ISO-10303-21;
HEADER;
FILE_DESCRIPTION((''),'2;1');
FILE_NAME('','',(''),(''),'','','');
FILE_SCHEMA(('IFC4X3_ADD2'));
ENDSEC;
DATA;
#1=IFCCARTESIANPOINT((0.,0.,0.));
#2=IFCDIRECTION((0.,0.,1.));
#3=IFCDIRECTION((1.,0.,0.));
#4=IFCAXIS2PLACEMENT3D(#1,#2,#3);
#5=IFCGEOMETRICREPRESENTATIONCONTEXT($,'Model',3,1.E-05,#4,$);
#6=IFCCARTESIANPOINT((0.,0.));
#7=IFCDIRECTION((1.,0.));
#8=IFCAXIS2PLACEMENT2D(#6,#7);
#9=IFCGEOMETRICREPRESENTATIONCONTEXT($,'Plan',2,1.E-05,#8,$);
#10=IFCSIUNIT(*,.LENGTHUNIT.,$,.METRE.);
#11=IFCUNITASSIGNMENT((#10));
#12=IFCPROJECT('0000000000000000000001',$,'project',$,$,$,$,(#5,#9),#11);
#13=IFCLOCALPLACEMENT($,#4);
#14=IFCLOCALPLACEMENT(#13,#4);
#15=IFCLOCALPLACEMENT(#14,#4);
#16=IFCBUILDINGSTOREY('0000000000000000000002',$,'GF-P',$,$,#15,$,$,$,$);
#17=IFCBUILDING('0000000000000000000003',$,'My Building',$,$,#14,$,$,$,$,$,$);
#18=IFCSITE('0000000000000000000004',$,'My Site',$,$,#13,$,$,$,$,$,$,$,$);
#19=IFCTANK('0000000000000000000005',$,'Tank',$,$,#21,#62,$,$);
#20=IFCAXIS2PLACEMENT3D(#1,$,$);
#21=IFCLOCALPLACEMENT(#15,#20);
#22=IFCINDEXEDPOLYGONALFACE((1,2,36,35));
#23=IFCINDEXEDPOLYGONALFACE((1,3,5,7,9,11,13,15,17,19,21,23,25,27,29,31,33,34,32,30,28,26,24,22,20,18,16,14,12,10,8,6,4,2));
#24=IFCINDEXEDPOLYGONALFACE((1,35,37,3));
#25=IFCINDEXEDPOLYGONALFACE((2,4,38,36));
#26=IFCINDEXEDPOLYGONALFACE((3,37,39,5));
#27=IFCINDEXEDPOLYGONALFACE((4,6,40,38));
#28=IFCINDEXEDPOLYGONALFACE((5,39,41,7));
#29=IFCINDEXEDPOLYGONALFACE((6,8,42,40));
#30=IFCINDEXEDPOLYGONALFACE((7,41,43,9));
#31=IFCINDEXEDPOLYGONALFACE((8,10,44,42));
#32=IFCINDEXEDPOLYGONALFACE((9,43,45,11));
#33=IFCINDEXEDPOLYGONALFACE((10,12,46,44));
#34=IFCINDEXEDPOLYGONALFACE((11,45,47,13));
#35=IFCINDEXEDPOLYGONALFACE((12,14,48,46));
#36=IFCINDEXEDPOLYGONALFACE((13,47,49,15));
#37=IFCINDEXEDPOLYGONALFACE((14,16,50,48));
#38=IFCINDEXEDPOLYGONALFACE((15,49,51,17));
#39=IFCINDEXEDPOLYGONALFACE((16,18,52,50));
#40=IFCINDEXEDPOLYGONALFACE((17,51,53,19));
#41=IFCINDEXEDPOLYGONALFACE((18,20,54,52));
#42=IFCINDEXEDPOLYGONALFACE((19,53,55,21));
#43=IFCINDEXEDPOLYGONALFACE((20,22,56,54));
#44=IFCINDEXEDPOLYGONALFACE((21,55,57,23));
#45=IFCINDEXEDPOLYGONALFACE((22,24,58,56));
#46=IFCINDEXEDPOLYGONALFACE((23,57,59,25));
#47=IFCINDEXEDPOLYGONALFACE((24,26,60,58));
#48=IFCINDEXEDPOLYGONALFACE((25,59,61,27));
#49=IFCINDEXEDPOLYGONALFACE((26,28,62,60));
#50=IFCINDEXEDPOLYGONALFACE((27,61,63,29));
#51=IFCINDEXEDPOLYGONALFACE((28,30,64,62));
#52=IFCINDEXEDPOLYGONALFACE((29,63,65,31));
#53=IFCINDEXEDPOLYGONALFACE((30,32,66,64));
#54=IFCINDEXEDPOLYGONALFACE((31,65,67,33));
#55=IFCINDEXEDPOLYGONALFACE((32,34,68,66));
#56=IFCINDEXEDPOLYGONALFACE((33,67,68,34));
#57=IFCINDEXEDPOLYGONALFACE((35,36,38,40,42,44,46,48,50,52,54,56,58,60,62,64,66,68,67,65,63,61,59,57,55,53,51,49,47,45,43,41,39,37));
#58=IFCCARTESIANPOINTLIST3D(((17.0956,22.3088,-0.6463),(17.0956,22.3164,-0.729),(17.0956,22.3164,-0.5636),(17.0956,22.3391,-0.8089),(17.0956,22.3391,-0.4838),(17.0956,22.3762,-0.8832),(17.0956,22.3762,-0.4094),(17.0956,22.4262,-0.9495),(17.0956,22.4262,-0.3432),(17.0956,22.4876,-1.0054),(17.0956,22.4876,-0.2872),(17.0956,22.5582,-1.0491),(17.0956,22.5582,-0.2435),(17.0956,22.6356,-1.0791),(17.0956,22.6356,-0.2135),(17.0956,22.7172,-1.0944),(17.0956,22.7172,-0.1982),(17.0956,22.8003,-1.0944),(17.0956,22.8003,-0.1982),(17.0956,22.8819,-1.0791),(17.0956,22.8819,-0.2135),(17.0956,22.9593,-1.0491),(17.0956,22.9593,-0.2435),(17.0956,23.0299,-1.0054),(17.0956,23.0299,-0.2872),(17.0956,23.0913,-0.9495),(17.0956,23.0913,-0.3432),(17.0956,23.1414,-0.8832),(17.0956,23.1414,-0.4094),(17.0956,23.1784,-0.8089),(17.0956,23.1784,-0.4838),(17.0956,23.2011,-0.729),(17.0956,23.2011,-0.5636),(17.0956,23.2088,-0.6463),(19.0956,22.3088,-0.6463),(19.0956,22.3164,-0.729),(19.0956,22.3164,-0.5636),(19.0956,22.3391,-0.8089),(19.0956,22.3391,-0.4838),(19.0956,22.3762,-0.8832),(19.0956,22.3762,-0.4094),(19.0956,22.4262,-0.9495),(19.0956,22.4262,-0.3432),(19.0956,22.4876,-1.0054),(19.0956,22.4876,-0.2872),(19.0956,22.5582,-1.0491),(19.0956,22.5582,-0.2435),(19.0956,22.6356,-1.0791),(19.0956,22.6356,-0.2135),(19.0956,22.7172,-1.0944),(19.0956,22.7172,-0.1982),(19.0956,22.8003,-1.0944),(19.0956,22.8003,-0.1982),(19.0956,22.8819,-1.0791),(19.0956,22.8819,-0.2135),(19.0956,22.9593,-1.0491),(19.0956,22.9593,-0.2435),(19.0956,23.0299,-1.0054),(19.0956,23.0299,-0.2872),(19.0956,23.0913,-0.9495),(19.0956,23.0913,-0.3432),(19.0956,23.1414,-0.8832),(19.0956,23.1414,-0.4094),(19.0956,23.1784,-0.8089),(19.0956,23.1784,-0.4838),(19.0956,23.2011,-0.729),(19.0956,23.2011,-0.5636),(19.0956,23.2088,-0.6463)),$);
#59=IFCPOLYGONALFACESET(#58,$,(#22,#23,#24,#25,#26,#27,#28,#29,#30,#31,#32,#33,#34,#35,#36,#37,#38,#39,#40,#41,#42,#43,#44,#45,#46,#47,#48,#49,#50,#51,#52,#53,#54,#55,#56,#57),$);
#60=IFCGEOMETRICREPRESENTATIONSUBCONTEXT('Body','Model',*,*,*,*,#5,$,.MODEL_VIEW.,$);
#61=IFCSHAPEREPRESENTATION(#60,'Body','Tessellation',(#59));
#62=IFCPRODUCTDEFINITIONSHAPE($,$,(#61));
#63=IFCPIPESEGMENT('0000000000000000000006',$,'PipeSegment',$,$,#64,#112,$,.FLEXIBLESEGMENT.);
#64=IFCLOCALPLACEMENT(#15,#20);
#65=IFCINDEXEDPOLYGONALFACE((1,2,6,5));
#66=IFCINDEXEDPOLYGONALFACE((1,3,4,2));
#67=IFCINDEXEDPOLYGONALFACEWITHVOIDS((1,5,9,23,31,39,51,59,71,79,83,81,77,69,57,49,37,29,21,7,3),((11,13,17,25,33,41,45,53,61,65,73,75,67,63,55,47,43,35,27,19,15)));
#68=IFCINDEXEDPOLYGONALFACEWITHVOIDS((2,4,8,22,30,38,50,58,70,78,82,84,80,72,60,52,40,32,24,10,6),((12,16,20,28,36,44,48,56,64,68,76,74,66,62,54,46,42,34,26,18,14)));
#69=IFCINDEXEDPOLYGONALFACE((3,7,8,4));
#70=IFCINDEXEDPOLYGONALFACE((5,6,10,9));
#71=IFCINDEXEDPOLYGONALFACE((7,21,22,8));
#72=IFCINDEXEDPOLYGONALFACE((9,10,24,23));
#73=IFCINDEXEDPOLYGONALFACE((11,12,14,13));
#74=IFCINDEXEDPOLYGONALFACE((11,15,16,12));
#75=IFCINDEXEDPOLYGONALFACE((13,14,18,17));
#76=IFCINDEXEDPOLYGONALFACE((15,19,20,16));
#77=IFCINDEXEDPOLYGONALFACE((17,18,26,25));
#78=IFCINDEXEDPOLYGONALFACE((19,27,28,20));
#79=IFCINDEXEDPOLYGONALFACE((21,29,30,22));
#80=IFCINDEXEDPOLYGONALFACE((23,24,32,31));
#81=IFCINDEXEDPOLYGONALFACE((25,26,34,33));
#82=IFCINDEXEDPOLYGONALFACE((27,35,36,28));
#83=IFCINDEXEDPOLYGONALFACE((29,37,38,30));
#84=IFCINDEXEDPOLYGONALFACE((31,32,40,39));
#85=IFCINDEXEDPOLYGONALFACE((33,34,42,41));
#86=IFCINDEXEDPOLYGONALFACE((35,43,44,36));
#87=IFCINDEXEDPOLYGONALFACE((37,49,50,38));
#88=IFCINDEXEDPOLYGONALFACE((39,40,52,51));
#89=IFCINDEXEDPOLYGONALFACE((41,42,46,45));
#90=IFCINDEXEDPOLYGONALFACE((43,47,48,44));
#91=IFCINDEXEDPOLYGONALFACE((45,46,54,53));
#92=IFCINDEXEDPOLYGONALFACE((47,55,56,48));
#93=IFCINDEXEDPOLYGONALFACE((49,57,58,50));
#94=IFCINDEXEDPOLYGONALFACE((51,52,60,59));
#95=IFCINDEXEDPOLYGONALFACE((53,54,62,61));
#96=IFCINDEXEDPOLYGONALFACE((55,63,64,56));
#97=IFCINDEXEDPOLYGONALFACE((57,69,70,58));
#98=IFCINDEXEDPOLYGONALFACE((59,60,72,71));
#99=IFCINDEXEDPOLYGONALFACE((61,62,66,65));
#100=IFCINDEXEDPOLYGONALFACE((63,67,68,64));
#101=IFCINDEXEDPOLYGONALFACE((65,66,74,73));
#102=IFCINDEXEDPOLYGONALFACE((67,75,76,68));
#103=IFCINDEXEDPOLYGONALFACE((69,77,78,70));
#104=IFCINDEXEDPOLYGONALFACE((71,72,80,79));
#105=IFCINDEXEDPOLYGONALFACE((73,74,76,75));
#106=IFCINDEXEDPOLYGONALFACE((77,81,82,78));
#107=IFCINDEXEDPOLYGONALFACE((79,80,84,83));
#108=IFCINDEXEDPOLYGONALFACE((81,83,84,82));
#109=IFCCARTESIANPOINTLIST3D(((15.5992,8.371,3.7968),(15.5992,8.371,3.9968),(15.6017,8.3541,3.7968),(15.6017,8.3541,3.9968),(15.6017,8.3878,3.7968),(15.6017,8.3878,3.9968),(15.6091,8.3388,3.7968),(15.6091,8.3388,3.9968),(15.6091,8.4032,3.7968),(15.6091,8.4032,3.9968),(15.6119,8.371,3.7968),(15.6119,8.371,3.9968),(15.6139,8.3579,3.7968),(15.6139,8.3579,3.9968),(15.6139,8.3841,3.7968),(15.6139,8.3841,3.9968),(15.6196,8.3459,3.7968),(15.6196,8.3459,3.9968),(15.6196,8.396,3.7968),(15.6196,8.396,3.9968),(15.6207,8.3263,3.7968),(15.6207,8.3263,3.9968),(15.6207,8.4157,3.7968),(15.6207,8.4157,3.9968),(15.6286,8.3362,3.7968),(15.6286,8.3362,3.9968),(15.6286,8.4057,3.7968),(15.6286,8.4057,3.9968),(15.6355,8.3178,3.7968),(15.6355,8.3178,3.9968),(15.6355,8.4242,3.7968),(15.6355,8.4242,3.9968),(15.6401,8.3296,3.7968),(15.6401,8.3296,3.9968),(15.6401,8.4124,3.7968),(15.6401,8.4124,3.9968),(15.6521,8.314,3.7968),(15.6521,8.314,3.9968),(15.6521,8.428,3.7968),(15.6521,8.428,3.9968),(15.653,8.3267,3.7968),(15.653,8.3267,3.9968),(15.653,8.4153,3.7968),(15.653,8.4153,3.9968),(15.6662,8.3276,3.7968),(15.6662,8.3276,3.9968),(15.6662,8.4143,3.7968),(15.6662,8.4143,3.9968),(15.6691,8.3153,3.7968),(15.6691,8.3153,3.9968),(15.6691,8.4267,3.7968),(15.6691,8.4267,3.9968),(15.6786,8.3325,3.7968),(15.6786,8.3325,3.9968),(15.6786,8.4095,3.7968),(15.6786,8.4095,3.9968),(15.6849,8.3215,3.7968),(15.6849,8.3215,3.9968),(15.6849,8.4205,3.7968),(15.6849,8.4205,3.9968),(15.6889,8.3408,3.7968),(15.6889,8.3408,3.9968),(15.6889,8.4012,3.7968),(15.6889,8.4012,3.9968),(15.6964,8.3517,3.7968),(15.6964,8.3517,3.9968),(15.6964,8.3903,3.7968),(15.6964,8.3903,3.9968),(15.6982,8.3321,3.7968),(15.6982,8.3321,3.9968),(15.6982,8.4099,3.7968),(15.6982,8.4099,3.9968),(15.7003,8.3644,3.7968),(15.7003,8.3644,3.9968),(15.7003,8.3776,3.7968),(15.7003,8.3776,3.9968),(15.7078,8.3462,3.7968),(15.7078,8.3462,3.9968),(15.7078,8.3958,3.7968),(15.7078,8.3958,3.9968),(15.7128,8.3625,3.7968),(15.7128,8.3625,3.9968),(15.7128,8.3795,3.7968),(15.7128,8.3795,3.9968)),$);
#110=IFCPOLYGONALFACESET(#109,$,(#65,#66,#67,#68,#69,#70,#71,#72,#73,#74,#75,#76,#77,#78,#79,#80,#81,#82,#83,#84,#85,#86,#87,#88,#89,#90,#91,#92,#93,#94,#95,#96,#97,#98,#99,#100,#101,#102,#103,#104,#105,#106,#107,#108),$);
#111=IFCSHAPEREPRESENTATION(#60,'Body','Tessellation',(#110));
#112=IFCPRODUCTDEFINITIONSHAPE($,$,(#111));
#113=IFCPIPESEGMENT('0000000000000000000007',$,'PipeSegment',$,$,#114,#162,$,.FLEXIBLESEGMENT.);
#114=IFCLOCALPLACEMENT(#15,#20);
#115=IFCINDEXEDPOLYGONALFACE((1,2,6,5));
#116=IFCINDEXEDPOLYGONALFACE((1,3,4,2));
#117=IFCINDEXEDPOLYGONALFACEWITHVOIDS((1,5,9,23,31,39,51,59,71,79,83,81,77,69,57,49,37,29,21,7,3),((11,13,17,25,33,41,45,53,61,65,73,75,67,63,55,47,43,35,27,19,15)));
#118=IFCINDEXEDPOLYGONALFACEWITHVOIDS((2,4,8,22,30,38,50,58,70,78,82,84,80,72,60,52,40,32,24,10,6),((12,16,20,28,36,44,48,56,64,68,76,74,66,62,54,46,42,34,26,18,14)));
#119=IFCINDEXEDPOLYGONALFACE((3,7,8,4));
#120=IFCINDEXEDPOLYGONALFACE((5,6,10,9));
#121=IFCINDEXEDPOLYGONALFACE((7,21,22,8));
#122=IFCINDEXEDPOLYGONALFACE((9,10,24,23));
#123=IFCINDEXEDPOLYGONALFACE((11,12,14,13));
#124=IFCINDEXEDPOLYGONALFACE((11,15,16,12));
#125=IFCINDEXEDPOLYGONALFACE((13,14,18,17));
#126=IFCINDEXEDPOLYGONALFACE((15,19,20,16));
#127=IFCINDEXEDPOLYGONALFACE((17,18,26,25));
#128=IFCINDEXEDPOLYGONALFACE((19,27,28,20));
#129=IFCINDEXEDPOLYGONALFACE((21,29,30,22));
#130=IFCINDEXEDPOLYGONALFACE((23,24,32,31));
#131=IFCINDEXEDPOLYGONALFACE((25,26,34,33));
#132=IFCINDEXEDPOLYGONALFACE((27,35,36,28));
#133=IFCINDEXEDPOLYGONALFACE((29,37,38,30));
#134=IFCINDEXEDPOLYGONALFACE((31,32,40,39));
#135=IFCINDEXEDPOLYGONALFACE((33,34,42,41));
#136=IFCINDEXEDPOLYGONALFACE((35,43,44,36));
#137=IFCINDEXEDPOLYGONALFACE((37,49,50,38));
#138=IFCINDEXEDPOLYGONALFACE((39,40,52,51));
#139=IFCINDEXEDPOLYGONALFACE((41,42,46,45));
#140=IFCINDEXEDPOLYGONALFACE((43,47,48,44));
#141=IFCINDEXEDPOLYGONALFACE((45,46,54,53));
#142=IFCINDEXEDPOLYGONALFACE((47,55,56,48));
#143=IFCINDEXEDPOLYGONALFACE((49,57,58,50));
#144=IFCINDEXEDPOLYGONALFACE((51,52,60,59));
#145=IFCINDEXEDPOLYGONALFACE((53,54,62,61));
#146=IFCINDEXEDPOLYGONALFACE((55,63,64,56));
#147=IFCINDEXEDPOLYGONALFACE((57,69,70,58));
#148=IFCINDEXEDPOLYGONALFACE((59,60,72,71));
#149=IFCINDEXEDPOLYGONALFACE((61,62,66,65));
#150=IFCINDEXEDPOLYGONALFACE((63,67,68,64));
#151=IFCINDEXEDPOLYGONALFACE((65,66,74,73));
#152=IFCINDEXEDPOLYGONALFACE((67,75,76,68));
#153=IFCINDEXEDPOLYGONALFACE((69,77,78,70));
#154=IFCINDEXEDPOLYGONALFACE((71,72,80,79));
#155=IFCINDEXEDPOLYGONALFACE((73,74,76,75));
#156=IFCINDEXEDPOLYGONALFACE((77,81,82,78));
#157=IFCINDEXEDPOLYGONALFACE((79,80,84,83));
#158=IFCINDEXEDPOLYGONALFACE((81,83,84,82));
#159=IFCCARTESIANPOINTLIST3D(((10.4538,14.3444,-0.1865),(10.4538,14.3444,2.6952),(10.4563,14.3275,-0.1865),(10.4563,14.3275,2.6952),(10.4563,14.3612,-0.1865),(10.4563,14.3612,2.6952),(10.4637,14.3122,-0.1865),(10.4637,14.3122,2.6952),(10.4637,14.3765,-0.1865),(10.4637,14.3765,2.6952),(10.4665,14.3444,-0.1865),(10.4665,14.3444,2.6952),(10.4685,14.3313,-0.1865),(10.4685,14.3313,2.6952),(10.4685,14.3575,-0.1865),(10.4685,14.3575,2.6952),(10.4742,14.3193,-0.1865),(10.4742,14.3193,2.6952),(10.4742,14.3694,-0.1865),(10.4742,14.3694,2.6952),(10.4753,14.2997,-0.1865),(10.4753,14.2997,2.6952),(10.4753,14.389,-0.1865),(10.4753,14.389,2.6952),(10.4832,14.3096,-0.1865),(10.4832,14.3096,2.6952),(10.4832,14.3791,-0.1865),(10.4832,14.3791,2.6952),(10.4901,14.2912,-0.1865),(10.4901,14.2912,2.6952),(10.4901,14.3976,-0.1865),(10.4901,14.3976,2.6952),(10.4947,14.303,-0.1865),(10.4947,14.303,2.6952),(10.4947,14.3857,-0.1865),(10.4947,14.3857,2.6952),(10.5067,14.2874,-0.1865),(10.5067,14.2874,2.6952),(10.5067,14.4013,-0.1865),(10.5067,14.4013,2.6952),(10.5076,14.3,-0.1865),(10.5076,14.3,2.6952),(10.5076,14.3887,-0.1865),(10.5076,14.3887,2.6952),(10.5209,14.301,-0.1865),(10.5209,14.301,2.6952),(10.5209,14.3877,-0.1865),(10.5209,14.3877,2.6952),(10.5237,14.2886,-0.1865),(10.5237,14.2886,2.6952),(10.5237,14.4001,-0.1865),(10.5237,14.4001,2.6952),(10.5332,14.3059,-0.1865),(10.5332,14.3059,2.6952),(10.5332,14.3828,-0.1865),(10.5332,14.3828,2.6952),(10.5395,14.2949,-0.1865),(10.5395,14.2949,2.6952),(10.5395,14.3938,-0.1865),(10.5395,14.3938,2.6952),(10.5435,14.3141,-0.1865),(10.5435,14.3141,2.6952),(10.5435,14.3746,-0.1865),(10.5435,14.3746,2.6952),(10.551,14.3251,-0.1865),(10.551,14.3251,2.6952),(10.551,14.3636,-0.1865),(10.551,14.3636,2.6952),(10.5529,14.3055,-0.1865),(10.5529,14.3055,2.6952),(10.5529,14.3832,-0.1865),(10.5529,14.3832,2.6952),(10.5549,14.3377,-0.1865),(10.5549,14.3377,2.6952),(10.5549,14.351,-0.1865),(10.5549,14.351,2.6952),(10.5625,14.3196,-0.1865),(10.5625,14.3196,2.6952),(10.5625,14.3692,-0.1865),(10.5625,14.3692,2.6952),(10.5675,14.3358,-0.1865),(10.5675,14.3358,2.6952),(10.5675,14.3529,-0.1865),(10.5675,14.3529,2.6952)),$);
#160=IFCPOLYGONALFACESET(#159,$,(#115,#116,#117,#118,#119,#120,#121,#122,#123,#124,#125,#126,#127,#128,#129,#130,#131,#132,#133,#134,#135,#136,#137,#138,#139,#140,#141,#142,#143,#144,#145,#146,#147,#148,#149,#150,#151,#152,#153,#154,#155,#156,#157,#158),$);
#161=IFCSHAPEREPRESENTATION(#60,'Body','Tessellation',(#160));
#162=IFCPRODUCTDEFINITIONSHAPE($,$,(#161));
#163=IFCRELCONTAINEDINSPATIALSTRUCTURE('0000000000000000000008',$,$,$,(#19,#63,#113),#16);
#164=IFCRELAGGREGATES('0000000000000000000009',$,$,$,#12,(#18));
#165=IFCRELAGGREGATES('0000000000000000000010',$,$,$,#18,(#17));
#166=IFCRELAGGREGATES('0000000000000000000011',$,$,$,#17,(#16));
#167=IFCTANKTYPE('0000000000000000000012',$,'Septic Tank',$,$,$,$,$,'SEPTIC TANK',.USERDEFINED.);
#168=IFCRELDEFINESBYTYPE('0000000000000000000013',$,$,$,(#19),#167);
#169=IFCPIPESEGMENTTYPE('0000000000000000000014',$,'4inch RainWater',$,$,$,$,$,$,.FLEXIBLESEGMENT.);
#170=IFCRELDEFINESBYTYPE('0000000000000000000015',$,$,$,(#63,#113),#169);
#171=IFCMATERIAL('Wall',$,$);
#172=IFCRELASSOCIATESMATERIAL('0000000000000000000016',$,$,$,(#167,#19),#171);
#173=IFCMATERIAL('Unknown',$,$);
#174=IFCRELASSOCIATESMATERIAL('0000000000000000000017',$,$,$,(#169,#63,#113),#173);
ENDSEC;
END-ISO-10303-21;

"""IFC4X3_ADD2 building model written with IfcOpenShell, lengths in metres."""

from ifc_helpers import new_model, si_unit, frame, origin_with_axes, origin_2d_with_axis, place, context, subcontext, project, spatial, circle, hollow_circle, extrude, material, material_profile, profile_set, profile_usage, type_object, element, save


model = new_model("IFC4X3_ADD2")

# Units and contexts
model_context = context("Model", 3, precision=1e-05, world=origin_with_axes())
plan_context = context("Plan", 2, precision=1e-05, world=origin_2d_with_axis())
body_context = subcontext(model_context, "Body", "Model", "MODEL_VIEW")
ifc_project = project(units=[si_unit("LENGTHUNIT", "METRE")], contexts=[model_context, plan_context])

# Site, building, storey
site_placement = place(None, origin_with_axes())
site = spatial("IfcSite", under=ifc_project, at=site_placement, Name="My Site")
building_placement = place(site_placement, origin_with_axes())
building = spatial("IfcBuilding", under=site, at=building_placement, Name="My Building")
storey_placement = place(building_placement, origin_with_axes())
storey = spatial("IfcBuildingStorey", under=building, at=storey_placement, Name="GF-P")

# Shared definitions
ifc_material_1 = material(Name="Unknown")
ifc_material_2 = material(Name="Wall")

# Tank
ifc_material_profile_1 = material_profile(ifc_material_2, circle(Radius=0.45))
ifc_profile_set_1 = profile_set([ifc_material_profile_1])
ifc_profile_usage_1 = profile_usage(ifc_profile_set_1, cardinal=5)
tank_type = type_object("IfcTankType", Name="Septic Tank", ElementType="SEPTIC TANK", PredefinedType="USERDEFINED", material=ifc_profile_set_1)
tank_placement = place(storey_placement, frame((17.0956, 22.7588, -0.6463), z_axis=(1.0, 0.0, 0.0), x_axis=(0.0, 1.0, 0.0)))
element("IfcTank", 1, at=tank_placement, inside=storey, type_object=tank_type, material=ifc_profile_usage_1, Name="Tank", context=body_context, shape_type="SweptSolid", body=[
    extrude(circle(Radius=0.45), origin_with_axes(), (0.0, 0.0, 1.0), 2.0),
])

# Pipe segments
ifc_material_profile_2 = material_profile(ifc_material_1, hollow_circle(Radius=0.0571, WallThickness=0.0127))
ifc_profile_set_2 = profile_set([ifc_material_profile_2], Name="rainwater")
ifc_profile_usage_2 = profile_usage(ifc_profile_set_2)
pipe_segment_type_1 = type_object("IfcPipeSegmentType", Name="4inch RainWater", PredefinedType="FLEXIBLESEGMENT", material=ifc_profile_set_2)
pipe_segment_1_placement = place(storey_placement, frame((15.6563, 8.371, 3.7968), z_axis=(0.0, 0.0, 1.0), x_axis=(-1.0, 0.0, 0.0)))
element("IfcPipeSegment", 2, at=pipe_segment_1_placement, inside=storey, type_object=pipe_segment_type_1, material=ifc_profile_usage_2, Name="PipeSegment", PredefinedType="FLEXIBLESEGMENT", context=body_context, shape_type="SweptSolid", body=[
    extrude(hollow_circle(Radius=0.0571, WallThickness=0.0127), origin_with_axes(), (0.0, 0.0, 1.0), 0.2),
])
ifc_profile_usage_3 = profile_usage(ifc_profile_set_2)
pipe_segment_2_placement = place(storey_placement, frame((10.511, 14.3444, -0.1865), z_axis=(0.0, 0.0, 1.0), x_axis=(-1.0, 0.0, 0.0)))
element("IfcPipeSegment", 3, at=pipe_segment_2_placement, inside=storey, type_object=pipe_segment_type_1, material=ifc_profile_usage_3, Name="PipeSegment", PredefinedType="FLEXIBLESEGMENT", context=body_context, shape_type="SweptSolid", body=[
    extrude(hollow_circle(Radius=0.0571, WallThickness=0.0127), origin_with_axes(), (0.0, 0.0, 1.0), 2.8817),
])

save(model, "model.ifc")
